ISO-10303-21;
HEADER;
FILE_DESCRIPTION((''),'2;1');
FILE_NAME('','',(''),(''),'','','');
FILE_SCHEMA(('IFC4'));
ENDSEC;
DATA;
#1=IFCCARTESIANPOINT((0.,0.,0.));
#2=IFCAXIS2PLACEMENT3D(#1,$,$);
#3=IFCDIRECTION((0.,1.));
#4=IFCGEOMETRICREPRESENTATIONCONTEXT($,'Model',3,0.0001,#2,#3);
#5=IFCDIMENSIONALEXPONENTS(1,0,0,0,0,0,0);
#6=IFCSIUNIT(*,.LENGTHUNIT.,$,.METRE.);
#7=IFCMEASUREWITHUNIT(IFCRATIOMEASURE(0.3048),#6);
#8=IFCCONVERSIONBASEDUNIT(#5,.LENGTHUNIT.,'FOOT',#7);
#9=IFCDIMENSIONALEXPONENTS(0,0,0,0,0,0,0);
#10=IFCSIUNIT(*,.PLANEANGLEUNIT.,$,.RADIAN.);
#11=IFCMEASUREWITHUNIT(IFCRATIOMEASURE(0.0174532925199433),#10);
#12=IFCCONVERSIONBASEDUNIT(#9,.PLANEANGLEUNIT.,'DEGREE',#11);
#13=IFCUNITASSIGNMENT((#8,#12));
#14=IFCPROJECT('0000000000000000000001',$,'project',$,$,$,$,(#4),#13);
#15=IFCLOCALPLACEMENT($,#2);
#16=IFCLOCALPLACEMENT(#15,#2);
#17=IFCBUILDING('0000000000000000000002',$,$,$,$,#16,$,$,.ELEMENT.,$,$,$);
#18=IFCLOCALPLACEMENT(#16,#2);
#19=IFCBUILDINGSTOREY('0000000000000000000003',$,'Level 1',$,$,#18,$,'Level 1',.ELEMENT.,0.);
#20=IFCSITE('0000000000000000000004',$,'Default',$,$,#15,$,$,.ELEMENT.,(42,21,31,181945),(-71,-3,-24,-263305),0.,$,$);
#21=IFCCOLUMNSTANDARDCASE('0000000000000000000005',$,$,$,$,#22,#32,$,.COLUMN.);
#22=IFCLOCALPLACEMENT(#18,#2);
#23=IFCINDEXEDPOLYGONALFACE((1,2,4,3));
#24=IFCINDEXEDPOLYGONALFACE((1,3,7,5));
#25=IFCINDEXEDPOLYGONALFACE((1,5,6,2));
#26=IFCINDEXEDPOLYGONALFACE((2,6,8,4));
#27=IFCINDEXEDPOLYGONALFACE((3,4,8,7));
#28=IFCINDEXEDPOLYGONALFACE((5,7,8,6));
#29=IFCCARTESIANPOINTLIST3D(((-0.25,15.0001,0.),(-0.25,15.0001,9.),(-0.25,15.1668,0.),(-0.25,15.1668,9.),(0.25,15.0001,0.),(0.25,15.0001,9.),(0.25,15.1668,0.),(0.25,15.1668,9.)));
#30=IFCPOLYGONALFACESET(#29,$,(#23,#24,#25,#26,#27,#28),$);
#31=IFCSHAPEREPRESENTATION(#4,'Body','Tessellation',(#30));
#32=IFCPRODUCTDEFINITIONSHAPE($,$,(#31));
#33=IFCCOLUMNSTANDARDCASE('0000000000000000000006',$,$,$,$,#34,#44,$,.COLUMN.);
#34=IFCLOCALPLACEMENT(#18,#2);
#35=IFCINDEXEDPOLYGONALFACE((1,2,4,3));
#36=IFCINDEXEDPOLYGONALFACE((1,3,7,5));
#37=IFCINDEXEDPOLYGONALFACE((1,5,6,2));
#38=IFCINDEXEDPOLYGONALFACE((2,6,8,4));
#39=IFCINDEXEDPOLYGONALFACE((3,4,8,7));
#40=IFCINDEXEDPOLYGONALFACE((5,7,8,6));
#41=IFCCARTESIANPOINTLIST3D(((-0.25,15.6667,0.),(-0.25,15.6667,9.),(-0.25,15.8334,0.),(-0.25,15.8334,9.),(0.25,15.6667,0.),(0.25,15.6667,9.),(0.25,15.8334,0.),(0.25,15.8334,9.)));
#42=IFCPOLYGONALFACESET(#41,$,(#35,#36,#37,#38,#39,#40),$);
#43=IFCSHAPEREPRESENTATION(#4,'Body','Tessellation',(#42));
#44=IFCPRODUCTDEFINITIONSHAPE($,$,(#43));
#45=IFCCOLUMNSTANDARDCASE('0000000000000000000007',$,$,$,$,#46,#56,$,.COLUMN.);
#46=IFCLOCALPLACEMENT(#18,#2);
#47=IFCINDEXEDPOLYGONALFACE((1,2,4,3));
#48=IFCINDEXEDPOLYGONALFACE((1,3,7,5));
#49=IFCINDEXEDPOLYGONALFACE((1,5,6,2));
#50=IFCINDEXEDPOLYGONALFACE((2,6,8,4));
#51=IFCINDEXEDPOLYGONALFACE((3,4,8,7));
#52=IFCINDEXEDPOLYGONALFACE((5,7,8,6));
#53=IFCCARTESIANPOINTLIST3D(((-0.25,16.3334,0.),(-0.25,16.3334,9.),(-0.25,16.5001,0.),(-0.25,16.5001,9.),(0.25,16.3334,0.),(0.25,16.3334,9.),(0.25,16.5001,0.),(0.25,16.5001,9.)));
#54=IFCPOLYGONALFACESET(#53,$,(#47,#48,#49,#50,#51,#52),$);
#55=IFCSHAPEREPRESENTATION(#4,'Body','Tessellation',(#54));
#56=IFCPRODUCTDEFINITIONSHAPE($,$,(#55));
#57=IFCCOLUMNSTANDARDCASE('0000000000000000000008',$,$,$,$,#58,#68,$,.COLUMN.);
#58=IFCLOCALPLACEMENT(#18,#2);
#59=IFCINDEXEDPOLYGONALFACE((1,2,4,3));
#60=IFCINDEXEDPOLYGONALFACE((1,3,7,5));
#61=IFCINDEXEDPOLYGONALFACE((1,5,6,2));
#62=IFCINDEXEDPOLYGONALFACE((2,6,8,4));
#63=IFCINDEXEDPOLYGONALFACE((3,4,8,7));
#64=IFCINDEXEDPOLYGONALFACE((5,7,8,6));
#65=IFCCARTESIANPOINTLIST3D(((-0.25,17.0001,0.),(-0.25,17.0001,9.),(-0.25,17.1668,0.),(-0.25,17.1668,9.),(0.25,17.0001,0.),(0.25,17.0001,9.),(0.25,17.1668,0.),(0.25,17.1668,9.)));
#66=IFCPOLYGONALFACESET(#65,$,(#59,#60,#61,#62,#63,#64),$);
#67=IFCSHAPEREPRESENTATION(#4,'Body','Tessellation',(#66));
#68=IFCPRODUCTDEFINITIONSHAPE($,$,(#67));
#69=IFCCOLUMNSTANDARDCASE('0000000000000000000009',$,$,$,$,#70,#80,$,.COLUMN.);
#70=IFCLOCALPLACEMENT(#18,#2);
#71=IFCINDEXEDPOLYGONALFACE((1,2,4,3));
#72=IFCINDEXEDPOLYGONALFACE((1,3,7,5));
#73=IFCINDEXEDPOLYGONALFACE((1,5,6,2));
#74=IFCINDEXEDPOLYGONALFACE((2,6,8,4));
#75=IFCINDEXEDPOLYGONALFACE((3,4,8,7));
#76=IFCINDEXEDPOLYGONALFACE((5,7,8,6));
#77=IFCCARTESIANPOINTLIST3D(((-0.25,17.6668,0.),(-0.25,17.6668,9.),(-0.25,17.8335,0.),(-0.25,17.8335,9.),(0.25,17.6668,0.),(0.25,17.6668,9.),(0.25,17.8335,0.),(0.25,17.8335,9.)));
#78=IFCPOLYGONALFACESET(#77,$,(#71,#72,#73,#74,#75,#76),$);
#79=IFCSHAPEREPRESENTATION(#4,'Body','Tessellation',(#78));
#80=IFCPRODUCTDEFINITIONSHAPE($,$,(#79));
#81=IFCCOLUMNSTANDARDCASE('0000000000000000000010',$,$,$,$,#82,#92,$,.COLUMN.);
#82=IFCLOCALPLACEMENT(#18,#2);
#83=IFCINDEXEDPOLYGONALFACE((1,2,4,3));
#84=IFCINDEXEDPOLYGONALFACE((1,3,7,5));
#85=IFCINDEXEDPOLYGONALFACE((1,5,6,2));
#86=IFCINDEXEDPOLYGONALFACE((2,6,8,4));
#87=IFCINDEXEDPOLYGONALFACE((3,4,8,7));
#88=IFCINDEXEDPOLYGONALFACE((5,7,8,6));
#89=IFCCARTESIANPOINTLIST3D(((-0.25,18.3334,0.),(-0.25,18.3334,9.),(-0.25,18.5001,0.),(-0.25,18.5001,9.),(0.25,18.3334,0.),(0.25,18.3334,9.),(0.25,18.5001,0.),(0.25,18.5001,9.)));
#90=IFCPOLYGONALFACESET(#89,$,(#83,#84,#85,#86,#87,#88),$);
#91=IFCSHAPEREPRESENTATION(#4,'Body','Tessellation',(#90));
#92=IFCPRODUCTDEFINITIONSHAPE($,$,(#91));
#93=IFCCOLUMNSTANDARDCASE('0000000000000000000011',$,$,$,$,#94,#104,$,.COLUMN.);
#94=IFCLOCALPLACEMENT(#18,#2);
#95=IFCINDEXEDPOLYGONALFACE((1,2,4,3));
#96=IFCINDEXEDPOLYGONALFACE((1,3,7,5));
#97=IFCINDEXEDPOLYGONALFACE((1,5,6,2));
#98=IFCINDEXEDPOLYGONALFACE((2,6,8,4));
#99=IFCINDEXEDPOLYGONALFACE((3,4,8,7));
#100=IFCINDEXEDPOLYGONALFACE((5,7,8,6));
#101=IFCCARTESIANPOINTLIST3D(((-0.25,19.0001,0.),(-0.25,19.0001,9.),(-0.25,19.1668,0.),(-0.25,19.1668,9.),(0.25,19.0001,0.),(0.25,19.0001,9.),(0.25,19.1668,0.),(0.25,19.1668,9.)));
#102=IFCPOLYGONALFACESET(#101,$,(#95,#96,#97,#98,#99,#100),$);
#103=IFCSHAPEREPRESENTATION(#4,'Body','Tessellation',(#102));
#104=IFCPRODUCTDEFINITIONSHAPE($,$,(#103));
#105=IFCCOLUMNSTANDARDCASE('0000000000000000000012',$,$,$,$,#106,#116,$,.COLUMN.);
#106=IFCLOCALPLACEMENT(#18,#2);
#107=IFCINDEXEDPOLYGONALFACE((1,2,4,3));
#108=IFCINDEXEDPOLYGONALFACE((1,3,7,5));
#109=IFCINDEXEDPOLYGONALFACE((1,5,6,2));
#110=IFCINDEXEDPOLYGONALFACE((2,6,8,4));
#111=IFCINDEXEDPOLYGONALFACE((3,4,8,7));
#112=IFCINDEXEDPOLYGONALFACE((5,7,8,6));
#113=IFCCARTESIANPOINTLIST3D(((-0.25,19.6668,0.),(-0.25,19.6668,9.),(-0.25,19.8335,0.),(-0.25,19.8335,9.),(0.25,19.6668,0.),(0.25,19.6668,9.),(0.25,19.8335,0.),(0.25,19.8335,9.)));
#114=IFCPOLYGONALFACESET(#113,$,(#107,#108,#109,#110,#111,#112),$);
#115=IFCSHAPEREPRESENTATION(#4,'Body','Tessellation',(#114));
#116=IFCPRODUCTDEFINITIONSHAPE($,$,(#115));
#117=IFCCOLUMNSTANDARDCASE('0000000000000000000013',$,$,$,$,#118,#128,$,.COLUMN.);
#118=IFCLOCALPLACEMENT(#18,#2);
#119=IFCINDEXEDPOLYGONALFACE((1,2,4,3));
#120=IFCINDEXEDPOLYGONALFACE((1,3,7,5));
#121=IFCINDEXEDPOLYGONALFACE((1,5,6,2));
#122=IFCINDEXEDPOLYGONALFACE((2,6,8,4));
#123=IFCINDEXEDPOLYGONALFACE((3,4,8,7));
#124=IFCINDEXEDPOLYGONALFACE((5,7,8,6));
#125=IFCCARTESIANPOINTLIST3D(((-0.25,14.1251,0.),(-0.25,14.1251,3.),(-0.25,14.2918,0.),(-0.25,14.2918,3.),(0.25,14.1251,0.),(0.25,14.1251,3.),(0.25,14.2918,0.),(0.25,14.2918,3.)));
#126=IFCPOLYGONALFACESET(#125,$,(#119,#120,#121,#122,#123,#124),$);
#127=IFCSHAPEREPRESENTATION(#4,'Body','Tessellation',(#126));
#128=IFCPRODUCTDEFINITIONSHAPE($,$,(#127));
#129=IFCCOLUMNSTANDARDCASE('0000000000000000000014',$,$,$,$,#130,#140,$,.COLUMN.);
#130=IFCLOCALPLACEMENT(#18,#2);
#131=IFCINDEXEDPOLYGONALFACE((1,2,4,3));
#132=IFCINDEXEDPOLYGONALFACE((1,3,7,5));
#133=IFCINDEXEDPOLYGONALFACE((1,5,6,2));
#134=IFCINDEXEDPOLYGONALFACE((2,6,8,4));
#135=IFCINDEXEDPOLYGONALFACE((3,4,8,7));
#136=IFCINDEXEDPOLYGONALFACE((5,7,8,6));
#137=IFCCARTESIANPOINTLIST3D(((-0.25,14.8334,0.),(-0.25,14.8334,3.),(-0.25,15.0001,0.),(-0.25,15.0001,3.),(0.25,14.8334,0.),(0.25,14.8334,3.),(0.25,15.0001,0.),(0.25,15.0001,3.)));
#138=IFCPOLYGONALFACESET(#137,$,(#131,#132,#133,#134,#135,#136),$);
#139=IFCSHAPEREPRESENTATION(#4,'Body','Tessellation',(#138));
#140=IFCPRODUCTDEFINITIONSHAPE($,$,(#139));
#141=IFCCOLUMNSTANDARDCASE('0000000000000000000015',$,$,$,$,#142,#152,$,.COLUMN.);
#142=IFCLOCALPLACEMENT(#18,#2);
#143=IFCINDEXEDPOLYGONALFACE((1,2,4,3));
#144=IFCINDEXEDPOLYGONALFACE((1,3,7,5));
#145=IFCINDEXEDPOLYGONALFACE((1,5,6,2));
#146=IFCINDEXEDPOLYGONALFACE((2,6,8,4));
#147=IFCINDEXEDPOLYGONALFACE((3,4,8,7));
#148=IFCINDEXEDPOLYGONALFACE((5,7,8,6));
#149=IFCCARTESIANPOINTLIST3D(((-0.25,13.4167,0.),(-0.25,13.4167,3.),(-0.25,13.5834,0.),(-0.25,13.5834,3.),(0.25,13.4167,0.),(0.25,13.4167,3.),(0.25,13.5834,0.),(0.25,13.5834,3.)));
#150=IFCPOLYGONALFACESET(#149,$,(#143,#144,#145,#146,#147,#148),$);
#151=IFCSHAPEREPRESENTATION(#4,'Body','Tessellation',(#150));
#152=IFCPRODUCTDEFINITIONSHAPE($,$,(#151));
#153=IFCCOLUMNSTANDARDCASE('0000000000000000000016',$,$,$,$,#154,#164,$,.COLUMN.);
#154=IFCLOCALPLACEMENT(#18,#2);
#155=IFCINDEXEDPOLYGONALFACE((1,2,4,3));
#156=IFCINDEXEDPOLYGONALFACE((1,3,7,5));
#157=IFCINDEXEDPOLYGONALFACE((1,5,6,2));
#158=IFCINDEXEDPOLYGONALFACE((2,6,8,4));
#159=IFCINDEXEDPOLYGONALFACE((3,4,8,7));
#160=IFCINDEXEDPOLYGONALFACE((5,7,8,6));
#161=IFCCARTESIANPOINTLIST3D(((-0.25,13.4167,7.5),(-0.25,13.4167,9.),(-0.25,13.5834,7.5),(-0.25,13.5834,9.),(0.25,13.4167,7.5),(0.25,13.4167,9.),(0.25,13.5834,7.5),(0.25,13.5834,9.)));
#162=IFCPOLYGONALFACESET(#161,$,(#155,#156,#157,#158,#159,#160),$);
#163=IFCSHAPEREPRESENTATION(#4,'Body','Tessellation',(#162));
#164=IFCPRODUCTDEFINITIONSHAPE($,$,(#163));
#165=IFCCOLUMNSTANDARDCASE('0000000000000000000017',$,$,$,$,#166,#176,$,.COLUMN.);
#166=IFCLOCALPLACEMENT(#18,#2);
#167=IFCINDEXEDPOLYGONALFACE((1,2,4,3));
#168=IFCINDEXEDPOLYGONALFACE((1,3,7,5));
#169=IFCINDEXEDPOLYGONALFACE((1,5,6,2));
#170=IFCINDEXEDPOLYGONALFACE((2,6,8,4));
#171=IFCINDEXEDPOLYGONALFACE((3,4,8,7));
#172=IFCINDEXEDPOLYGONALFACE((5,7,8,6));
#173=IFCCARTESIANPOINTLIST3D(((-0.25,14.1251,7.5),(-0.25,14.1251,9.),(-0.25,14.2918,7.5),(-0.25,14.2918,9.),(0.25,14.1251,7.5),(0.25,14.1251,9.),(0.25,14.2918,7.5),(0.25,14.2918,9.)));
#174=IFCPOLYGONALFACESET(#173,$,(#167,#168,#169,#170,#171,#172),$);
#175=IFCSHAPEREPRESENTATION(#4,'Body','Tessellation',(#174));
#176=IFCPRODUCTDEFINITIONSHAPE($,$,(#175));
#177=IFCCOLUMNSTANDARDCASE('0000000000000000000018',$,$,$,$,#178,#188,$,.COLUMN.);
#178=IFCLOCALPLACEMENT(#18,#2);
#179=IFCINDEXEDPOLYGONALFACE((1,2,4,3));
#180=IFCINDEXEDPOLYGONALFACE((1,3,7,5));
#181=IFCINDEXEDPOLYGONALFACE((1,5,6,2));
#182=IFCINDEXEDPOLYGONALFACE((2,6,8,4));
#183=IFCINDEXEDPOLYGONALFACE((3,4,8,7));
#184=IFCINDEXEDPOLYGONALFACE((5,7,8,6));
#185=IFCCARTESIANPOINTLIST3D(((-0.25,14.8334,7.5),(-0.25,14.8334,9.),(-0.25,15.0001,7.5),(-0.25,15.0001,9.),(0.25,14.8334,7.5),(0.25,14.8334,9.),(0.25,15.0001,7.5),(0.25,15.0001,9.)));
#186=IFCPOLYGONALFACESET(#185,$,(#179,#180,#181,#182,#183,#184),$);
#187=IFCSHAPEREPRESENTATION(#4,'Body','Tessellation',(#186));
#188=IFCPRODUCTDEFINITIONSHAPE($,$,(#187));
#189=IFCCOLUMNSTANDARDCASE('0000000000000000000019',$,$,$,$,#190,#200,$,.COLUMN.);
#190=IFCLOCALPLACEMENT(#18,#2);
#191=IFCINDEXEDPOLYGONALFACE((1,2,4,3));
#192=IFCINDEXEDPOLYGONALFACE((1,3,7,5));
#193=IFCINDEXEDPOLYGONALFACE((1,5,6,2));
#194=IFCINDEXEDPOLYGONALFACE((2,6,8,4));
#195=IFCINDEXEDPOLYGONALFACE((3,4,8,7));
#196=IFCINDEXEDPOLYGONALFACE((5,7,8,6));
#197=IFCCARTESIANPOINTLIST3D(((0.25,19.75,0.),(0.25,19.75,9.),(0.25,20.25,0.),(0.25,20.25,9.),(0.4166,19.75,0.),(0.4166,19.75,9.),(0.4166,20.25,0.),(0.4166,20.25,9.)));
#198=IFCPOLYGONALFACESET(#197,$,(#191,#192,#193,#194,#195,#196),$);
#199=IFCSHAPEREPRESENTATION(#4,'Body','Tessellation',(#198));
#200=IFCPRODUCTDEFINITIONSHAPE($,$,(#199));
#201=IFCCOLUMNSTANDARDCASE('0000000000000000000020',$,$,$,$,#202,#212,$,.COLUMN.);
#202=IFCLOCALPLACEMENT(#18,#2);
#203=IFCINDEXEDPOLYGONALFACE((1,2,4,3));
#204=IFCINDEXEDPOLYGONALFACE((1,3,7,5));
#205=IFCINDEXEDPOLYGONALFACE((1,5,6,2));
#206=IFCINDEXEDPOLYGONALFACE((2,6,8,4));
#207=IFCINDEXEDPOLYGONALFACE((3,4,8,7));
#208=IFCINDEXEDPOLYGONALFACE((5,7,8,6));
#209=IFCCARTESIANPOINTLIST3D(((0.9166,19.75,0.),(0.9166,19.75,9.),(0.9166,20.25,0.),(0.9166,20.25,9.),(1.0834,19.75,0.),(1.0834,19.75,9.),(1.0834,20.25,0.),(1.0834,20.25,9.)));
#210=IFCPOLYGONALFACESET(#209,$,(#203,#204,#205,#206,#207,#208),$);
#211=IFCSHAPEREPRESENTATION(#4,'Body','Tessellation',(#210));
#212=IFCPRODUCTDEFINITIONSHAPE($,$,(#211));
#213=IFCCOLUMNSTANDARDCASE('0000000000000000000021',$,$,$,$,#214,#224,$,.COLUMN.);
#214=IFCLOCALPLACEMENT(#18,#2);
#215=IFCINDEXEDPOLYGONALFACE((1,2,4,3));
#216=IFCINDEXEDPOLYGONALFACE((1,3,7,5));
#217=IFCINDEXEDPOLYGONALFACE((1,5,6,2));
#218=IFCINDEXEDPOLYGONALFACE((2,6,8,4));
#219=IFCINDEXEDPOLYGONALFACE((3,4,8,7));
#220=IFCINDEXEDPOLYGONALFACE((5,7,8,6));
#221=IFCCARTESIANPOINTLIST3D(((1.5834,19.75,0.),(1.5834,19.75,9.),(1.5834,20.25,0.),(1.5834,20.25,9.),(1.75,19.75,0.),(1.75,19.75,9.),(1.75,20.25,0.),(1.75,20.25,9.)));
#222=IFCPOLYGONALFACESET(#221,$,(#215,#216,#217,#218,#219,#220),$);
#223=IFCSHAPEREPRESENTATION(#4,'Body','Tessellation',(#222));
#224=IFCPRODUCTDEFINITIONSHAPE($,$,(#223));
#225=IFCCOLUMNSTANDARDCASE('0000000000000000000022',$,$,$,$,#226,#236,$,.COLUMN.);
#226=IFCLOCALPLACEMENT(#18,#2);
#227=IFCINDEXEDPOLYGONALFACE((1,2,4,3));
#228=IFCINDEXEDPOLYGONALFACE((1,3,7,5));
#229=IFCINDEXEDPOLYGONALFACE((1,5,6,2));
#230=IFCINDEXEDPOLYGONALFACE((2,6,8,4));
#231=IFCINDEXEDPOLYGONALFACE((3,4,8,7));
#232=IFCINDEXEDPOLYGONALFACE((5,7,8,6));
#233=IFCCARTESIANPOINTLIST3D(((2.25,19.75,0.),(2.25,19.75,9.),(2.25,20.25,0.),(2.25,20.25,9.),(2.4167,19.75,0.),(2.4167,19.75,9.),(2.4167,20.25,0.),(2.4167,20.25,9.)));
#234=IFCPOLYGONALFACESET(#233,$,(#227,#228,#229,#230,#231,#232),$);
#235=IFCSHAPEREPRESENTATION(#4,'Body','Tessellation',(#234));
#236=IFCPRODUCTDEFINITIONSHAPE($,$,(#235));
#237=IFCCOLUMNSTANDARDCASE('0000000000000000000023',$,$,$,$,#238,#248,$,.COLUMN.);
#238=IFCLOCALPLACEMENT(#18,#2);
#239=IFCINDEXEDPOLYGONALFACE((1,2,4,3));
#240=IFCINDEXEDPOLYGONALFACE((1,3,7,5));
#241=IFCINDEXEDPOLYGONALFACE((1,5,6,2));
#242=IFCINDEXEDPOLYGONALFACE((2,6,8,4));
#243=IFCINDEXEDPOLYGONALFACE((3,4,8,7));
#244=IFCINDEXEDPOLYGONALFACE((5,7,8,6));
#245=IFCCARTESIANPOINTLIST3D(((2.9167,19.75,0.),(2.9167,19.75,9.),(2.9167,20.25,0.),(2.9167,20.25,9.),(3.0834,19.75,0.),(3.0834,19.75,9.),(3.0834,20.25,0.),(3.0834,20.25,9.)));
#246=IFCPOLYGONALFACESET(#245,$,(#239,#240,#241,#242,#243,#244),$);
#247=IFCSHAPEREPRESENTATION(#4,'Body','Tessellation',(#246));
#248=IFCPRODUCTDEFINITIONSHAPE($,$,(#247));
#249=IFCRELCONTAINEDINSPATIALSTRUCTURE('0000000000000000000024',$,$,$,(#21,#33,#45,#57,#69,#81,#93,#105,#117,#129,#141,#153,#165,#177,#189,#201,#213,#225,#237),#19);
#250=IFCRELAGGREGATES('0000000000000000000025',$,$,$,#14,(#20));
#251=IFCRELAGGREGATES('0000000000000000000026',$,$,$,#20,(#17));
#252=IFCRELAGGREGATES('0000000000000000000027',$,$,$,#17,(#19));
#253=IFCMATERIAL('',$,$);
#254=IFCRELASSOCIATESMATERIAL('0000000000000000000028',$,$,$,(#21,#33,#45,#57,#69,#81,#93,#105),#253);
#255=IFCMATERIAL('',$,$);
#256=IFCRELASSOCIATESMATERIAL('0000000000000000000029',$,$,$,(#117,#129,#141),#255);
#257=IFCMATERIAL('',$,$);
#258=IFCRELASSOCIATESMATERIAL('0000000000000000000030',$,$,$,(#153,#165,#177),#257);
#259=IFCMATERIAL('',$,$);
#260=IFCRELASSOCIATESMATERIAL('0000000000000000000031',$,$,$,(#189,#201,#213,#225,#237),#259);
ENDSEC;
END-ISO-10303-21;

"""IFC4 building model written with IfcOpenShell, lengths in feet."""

from ifc_helpers import new_model, entity, si_unit, converted_unit, direction, frame, origin, place, context, project, spatial, rectangle, extrude, material, element, save


model = new_model("IFC4")

# Units and contexts
model_context = context("Model", 3, precision=0.0001, world=origin(), true_north=direction((0.0, 1.0)))
ifc_project = project(units=[converted_unit("LENGTHUNIT", "FOOT", entity("IfcRatioMeasure", 0.3048), si_unit("LENGTHUNIT", "METRE"), dimensions=[1, 0, 0, 0, 0, 0, 0]), converted_unit("PLANEANGLEUNIT", "DEGREE", entity("IfcRatioMeasure", 0.0174532925199433), si_unit("PLANEANGLEUNIT", "RADIAN"), dimensions=[0, 0, 0, 0, 0, 0, 0])], contexts=[model_context])

# Site, building, storey
site_placement = place(None, origin())
site = spatial("IfcSite", under=ifc_project, at=site_placement, Name="Default", CompositionType="ELEMENT", RefLatitude=(42, 21, 31, 181945), RefLongitude=(-71, -3, -24, -263305), RefElevation=0.0)
building_placement = place(site_placement, origin())
building = spatial("IfcBuilding", under=site, at=building_placement, CompositionType="ELEMENT")
storey_placement = place(building_placement, origin())
storey = spatial("IfcBuildingStorey", under=building, at=storey_placement, Name="Level 1", LongName="Level 1", CompositionType="ELEMENT", Elevation=0.0)

# Columns
ifc_material_1 = material(Name="")
placement_1 = place(storey_placement, frame((0.0, -0.25, 0.0), z_axis=(0.0, 0.0, 1.0), x_axis=(0.0, 1.0, 0.0)))
for number, where, z_axis, x_axis in (
    (1, (15.3334, 0.0, 0.0), (0.0, 0.0, 1.0), (1.0, 0.0, 0.0)),
    (2, (16.0, 0.0, 0.0), (0.0, 0.0, 1.0), (1.0, 0.0, 0.0)),
    (3, (16.6667, 0.0, 0.0), (0.0, 0.0, 1.0), (1.0, 0.0, 0.0)),
    (4, (17.3334, 0.0, 0.0), (0.0, 0.0, 1.0), (1.0, 0.0, 0.0)),
    (5, (18.0001, 0.0, 0.0), (0.0, 0.0, 1.0), (1.0, 0.0, 0.0)),
    (6, (18.6667, 0.0, 0.0), (0.0, 0.0, 1.0), (1.0, 0.0, 0.0)),
    (7, (19.3334, 0.0, 0.0), (0.0, 0.0, 1.0), (1.0, 0.0, 0.0)),
    (8, (20.0001, 0.0, 0.0), (0.0, 0.0, 1.0), (1.0, 0.0, 0.0)),
):
    element("IfcColumnStandardCase", number, at=place(placement_1, frame(where, z_axis=z_axis, x_axis=x_axis)), inside=storey, material=ifc_material_1, PredefinedType="COLUMN", context=model_context, shape_type="SweptSolid", body=[
        extrude(rectangle(XDim=0.1667, YDim=0.5), origin(), (0.0, 0.0, 1.0), 9.0),
    ])
ifc_material_2 = material(Name="")
for number, where, z_axis, x_axis in (
    (9, (14.4584, 0.0, 0.0), (0.0, 0.0, 1.0), (1.0, 0.0, 0.0)),
    (10, (15.1667, 0.0, 0.0), (0.0, 0.0, 1.0), (1.0, 0.0, 0.0)),
    (11, (13.75, 0.0, 0.0), (0.0, 0.0, 1.0), (1.0, 0.0, 0.0)),
):
    element("IfcColumnStandardCase", number, at=place(placement_1, frame(where, z_axis=z_axis, x_axis=x_axis)), inside=storey, material=ifc_material_2, PredefinedType="COLUMN", context=model_context, shape_type="SweptSolid", body=[
        extrude(rectangle(XDim=0.1667, YDim=0.5), origin(), (0.0, 0.0, 1.0), 3.0),
    ])
ifc_material_3 = material(Name="")
for number, where, z_axis, x_axis in (
    (12, (13.75, 0.0, 7.5), (0.0, 0.0, 1.0), (1.0, 0.0, 0.0)),
    (13, (14.4584, 0.0, 7.5), (0.0, 0.0, 1.0), (1.0, 0.0, 0.0)),
    (14, (15.1667, 0.0, 7.5), (0.0, 0.0, 1.0), (1.0, 0.0, 0.0)),
):
    element("IfcColumnStandardCase", number, at=place(placement_1, frame(where, z_axis=z_axis, x_axis=x_axis)), inside=storey, material=ifc_material_3, PredefinedType="COLUMN", context=model_context, shape_type="SweptSolid", body=[
        extrude(rectangle(XDim=0.1667, YDim=0.5), origin(), (0.0, 0.0, 1.0), 1.5),
    ])
ifc_material_4 = material(Name="")
placement_2 = place(storey_placement, frame((0.25, 20.0, 0.0)))
for number, where, z_axis, x_axis in (
    (15, (0.0833, 0.0, 0.0), (0.0, 0.0, 1.0), (1.0, 0.0, 0.0)),
    (16, (0.75, 0.0, 0.0), (0.0, 0.0, 1.0), (1.0, 0.0, 0.0)),
    (17, (1.4167, 0.0, 0.0), (0.0, 0.0, 1.0), (1.0, 0.0, 0.0)),
    (18, (2.0833, 0.0, 0.0), (0.0, 0.0, 1.0), (1.0, 0.0, 0.0)),
    (19, (2.75, 0.0, 0.0), (0.0, 0.0, 1.0), (1.0, 0.0, 0.0)),
):
    element("IfcColumnStandardCase", number, at=place(placement_2, frame(where, z_axis=z_axis, x_axis=x_axis)), inside=storey, material=ifc_material_4, PredefinedType="COLUMN", context=model_context, shape_type="SweptSolid", body=[
        extrude(rectangle(XDim=0.1667, YDim=0.5), origin(), (0.0, 0.0, 1.0), 9.0),
    ])

save(model, "model.ifc")
